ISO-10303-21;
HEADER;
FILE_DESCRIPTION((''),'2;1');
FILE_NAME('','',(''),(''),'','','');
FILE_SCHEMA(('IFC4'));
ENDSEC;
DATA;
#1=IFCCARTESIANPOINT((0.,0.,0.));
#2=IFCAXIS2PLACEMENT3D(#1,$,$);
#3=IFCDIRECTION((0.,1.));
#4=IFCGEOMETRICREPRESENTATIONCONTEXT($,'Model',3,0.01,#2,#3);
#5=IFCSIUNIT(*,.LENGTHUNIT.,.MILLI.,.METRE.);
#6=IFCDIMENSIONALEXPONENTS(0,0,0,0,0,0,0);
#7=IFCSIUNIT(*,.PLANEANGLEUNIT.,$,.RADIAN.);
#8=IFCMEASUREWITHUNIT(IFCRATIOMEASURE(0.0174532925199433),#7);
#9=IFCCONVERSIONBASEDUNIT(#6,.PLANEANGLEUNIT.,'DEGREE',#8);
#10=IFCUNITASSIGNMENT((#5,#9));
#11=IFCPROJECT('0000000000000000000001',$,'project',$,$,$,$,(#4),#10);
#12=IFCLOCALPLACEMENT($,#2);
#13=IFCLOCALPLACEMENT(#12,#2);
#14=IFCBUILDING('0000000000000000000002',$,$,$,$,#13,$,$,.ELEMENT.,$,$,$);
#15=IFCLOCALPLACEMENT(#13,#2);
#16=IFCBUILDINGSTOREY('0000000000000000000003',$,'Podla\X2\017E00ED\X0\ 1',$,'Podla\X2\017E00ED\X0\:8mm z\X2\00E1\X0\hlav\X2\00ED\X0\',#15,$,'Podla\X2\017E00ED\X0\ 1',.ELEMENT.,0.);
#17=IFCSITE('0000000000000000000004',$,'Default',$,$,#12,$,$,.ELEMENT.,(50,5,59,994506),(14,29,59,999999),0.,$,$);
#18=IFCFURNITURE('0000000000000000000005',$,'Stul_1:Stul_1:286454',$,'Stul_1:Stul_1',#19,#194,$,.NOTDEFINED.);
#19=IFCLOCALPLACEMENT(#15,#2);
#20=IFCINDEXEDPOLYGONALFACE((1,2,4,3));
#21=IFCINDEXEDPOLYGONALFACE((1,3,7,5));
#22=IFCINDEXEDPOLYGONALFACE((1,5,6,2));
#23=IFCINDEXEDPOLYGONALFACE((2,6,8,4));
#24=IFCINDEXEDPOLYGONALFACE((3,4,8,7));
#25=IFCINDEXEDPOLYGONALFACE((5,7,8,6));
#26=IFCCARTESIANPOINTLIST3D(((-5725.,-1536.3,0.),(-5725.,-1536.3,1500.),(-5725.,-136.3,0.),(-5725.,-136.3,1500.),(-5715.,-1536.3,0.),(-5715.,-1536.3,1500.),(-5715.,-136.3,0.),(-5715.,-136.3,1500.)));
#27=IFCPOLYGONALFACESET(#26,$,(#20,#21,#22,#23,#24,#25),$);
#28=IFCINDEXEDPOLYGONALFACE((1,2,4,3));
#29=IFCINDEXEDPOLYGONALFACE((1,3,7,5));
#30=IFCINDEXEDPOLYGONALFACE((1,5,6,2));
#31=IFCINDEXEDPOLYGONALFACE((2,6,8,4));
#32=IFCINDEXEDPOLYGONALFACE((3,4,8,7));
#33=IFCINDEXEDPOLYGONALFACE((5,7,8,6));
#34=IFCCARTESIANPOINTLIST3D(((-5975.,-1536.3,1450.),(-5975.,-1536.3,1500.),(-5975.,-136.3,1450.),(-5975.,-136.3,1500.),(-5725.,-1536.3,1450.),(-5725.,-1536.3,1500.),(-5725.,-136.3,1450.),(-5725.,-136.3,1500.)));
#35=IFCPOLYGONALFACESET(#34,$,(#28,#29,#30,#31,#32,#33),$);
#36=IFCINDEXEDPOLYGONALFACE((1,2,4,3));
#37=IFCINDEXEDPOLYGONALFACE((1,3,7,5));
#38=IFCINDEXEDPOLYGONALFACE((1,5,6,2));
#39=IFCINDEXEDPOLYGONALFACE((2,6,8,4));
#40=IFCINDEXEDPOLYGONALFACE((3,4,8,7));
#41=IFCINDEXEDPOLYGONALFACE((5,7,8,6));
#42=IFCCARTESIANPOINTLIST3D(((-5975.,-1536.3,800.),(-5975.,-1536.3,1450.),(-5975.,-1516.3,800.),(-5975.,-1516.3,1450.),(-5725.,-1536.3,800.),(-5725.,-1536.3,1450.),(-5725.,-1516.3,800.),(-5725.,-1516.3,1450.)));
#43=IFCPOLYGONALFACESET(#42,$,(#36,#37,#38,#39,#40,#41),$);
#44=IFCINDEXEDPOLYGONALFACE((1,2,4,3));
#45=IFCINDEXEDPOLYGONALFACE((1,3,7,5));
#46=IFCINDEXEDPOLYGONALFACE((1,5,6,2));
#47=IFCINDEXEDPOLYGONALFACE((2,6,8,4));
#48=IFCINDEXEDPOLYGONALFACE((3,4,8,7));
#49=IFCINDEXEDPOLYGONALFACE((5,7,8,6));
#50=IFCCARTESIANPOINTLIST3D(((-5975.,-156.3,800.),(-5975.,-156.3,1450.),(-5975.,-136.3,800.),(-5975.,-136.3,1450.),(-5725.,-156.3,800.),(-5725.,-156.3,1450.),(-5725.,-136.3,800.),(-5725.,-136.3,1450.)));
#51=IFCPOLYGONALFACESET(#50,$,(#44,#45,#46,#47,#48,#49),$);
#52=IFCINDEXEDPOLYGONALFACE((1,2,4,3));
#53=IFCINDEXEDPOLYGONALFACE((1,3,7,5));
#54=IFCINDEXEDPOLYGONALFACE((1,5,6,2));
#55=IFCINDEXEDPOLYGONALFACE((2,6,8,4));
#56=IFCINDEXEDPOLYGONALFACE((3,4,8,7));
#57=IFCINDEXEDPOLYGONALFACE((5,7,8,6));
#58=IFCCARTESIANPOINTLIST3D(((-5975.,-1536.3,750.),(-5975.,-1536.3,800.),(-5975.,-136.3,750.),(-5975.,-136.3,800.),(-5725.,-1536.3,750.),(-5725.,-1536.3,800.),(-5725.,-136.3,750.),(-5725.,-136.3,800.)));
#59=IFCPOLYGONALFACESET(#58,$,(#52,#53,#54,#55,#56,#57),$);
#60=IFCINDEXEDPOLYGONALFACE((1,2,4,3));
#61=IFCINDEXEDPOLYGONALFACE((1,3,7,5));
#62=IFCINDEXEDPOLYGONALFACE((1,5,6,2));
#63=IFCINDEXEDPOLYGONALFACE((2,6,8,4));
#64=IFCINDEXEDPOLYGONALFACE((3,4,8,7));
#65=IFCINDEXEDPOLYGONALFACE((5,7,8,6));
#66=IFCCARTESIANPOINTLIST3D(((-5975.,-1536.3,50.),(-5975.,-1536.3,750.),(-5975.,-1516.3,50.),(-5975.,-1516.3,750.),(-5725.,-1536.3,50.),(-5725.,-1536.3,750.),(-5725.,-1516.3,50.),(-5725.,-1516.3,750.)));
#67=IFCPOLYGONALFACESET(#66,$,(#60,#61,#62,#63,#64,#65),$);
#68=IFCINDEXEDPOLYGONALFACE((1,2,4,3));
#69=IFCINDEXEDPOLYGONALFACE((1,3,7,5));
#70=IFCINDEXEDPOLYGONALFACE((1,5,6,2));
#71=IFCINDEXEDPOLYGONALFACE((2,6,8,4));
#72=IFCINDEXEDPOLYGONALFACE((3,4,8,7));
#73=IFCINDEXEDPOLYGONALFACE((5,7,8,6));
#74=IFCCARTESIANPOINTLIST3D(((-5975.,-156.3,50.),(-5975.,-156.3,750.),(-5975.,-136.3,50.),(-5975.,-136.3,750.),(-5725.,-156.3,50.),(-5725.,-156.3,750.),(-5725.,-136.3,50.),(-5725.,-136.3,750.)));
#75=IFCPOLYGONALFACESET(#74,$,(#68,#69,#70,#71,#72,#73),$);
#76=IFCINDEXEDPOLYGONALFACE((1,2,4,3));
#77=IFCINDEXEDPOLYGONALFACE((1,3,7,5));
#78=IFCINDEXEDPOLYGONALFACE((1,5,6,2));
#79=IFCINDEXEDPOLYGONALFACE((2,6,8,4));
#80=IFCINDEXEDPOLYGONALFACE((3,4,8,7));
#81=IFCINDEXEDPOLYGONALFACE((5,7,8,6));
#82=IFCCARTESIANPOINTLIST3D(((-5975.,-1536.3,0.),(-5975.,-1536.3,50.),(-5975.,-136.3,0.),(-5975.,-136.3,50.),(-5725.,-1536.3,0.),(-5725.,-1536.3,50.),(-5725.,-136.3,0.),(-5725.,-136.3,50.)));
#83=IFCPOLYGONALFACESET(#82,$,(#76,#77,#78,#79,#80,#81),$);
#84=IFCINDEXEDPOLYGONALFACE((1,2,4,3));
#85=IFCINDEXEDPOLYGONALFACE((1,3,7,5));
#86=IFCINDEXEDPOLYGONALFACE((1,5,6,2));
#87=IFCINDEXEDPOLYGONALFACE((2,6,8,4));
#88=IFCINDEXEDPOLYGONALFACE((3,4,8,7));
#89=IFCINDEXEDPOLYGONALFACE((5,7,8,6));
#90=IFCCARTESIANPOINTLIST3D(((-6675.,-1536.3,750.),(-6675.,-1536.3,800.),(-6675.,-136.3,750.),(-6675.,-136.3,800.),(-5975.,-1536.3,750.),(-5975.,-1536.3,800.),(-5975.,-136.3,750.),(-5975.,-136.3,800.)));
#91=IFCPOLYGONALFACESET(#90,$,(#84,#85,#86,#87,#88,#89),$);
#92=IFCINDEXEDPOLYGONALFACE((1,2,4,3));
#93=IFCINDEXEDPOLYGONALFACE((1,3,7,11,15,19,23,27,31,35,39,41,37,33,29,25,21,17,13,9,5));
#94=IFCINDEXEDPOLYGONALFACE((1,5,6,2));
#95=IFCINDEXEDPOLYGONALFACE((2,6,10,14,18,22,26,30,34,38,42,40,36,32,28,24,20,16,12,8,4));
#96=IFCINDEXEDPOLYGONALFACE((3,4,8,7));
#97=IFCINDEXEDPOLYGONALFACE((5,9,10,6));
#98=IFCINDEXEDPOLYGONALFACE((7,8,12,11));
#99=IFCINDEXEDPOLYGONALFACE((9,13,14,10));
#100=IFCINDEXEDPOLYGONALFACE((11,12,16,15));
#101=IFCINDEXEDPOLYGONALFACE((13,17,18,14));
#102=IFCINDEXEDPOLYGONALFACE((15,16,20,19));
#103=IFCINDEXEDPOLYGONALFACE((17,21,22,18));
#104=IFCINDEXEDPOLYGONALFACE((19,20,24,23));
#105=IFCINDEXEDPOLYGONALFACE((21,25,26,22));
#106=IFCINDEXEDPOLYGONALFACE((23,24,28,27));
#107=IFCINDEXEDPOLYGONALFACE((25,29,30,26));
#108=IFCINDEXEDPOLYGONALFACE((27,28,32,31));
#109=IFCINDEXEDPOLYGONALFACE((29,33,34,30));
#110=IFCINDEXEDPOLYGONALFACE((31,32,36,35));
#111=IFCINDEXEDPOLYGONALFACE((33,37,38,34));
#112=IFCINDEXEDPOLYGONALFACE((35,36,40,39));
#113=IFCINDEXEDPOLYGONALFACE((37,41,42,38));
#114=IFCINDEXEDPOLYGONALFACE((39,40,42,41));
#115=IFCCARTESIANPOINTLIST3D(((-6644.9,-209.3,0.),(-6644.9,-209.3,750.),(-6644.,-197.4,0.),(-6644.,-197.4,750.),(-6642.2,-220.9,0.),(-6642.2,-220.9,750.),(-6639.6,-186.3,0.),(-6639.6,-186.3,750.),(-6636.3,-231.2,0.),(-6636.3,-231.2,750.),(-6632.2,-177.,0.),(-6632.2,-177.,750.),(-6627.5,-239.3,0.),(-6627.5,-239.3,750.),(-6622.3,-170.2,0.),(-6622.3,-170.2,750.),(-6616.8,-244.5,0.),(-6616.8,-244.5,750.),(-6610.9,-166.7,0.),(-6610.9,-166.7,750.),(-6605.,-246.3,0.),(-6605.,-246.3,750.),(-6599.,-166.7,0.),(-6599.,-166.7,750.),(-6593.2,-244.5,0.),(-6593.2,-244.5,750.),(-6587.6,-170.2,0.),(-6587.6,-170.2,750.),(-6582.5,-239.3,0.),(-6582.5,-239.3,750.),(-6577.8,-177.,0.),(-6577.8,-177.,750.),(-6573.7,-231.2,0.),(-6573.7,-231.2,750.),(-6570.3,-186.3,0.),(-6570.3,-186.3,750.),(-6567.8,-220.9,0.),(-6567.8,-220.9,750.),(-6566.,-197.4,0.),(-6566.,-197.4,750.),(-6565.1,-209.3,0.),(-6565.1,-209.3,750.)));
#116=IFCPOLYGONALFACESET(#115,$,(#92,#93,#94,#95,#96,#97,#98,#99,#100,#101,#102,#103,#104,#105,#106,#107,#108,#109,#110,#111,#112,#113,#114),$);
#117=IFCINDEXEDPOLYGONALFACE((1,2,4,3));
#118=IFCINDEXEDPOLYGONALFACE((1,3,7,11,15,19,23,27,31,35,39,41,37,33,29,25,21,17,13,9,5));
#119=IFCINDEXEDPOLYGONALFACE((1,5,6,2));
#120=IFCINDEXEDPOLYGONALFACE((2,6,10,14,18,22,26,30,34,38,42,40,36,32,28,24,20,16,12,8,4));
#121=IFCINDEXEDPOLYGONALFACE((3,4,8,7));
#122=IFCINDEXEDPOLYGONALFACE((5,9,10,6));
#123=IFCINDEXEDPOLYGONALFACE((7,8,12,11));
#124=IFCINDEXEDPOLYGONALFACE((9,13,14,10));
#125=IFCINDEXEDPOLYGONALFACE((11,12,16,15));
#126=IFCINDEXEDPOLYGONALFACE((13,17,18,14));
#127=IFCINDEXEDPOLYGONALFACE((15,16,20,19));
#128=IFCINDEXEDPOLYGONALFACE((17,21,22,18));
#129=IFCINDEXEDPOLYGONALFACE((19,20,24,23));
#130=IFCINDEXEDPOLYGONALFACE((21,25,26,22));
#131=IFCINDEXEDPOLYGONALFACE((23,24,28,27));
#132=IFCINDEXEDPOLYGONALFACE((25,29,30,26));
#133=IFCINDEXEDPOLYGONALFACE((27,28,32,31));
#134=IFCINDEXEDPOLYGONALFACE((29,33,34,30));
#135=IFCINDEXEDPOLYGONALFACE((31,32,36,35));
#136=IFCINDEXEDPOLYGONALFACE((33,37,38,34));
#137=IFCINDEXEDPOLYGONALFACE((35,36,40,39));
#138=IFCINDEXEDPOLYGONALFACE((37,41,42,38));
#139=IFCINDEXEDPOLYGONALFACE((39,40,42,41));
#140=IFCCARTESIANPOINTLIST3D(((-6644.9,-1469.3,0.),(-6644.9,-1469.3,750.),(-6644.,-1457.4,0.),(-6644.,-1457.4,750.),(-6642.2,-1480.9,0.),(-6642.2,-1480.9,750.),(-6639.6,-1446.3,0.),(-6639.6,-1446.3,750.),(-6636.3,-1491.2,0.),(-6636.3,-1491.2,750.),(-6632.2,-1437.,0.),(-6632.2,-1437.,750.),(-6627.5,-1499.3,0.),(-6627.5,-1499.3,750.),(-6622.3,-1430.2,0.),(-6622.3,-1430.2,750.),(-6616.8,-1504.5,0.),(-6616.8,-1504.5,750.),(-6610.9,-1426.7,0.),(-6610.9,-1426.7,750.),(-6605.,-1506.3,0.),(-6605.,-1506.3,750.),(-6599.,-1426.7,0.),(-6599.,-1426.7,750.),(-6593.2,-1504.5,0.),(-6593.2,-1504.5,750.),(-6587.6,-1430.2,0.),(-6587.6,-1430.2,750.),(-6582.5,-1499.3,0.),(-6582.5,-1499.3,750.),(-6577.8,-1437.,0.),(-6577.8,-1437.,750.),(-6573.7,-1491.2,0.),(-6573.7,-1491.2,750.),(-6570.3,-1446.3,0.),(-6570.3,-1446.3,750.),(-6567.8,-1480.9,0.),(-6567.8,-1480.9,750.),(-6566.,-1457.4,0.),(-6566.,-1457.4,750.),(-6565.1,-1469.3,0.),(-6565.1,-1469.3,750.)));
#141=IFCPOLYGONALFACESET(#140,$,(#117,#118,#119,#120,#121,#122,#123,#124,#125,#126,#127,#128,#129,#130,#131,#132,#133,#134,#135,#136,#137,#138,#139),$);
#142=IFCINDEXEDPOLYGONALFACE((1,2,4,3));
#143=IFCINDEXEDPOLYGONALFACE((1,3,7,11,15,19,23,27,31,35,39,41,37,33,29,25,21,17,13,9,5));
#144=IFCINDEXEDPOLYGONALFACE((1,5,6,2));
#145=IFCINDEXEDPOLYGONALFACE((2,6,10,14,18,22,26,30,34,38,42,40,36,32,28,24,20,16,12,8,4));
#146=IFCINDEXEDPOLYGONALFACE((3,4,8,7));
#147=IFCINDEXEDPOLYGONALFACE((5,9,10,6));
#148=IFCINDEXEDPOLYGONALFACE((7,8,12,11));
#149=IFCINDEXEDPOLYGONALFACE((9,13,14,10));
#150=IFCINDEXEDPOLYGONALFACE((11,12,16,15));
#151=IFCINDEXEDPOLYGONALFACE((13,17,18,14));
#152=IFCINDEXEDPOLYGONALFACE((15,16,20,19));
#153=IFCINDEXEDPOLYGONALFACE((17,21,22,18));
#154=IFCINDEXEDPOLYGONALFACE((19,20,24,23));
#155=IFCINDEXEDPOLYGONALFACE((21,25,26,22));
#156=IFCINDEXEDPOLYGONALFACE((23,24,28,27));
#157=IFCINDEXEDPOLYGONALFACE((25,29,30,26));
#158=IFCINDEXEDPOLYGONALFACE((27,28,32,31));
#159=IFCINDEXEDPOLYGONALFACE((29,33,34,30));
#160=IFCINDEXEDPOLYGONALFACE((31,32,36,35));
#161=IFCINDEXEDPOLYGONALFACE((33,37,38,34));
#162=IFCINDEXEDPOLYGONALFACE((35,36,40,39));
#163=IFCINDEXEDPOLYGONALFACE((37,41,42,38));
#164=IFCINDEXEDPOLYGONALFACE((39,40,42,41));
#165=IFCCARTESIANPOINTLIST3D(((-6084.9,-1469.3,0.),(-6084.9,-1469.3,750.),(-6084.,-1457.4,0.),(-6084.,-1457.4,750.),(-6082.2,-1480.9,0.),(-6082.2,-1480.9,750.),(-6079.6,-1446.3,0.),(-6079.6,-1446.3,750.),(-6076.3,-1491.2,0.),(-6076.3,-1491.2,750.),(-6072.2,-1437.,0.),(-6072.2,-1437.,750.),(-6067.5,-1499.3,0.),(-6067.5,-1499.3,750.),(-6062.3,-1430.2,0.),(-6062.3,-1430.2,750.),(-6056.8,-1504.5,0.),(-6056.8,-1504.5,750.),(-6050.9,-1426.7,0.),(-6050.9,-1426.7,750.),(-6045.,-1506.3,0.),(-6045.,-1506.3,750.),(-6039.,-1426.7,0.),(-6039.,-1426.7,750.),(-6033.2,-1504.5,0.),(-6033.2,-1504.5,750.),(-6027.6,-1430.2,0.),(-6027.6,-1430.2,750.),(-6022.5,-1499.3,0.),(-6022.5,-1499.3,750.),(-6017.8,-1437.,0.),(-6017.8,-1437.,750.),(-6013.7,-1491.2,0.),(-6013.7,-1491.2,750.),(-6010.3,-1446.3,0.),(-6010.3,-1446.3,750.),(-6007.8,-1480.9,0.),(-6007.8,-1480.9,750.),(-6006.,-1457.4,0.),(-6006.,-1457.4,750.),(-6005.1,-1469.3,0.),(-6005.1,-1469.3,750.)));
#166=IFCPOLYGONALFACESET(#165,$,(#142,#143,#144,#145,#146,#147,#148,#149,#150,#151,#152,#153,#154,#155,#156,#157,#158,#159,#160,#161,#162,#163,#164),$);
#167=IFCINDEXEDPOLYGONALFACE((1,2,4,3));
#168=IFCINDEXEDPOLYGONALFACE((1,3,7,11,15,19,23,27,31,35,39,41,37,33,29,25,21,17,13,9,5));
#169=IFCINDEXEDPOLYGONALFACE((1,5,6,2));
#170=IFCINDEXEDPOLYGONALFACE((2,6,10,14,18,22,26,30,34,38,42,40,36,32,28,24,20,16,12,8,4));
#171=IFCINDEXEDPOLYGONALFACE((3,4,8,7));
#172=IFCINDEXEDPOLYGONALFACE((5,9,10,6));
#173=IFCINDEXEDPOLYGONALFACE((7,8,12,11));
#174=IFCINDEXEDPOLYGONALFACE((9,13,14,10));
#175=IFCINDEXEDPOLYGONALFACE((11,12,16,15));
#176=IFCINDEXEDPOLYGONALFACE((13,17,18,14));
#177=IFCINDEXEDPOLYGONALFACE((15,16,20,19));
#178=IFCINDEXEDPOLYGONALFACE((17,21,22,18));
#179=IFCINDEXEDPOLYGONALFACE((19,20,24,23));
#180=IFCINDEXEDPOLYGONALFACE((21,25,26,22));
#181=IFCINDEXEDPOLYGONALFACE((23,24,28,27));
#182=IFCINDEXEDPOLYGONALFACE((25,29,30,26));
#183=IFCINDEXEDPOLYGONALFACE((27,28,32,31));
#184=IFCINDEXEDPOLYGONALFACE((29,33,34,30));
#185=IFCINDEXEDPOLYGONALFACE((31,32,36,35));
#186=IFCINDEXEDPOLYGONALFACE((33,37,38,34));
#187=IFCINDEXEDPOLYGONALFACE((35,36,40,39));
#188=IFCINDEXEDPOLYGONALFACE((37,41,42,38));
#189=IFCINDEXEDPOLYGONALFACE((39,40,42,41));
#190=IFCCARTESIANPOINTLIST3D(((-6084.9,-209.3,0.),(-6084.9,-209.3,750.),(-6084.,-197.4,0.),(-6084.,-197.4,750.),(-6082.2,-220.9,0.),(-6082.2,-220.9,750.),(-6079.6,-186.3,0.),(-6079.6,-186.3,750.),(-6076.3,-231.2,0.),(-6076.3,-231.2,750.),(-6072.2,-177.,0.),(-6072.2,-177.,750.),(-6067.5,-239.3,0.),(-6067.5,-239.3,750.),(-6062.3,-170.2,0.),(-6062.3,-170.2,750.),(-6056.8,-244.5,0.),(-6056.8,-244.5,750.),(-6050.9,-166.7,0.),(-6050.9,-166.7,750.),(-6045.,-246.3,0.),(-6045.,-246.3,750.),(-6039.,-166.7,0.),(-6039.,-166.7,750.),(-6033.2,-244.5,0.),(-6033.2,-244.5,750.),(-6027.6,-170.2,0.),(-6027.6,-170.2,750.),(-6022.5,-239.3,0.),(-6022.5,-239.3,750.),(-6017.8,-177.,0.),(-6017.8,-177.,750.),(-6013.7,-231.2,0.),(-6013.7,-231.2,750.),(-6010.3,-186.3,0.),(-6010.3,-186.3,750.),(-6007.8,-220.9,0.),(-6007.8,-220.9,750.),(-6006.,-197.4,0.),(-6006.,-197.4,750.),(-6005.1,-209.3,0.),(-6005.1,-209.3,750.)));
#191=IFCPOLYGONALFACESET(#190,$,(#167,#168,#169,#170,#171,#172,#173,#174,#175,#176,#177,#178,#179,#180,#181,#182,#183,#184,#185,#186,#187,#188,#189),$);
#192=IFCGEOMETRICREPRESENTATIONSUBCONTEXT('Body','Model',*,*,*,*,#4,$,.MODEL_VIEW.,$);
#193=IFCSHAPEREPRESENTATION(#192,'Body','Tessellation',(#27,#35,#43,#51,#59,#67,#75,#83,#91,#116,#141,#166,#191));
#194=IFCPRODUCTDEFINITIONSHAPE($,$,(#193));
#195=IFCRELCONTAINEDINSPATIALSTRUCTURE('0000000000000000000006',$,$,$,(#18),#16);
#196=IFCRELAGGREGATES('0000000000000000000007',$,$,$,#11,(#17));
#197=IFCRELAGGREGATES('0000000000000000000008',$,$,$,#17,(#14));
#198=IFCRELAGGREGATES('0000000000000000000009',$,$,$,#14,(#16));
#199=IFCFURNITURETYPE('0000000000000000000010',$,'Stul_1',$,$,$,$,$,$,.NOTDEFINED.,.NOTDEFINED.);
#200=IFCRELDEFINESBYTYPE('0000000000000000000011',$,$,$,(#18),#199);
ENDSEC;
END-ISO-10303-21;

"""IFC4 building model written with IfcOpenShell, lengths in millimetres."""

from ifc_helpers import new_model, entity, si_unit, converted_unit, direction, frame, frame_2d, origin, origin_2d_with_axis, place, context, subcontext, project, spatial, rectangle, circle, extrude, source, transform, mapped, type_object, type_shapes, element, save


model = new_model("IFC4")

# Units and contexts
model_context = context("Model", 3, precision=0.01, world=origin(), true_north=direction((0.0, 1.0)))
body_context = subcontext(model_context, "Body", "Model", "MODEL_VIEW")
ifc_project = project(units=[si_unit("LENGTHUNIT", "METRE", prefix="MILLI"), converted_unit("PLANEANGLEUNIT", "DEGREE", entity("IfcRatioMeasure", 0.0174532925199433), si_unit("PLANEANGLEUNIT", "RADIAN"), dimensions=[0, 0, 0, 0, 0, 0, 0])], contexts=[model_context])

# Site, building, storey
site_placement = place(None, origin())
site = spatial("IfcSite", under=ifc_project, at=site_placement, Name="Default", CompositionType="ELEMENT", RefLatitude=(50, 5, 59, 994506), RefLongitude=(14, 29, 59, 999999), RefElevation=0.0)
building_placement = place(site_placement, origin())
building = spatial("IfcBuilding", under=site, at=building_placement, CompositionType="ELEMENT")
storey_placement = place(building_placement, origin())
storey = spatial("IfcBuildingStorey", under=building, at=storey_placement, Name="Podlaží 1", ObjectType="Podlaží:8mm záhlaví", LongName="Podlaží 1", CompositionType="ELEMENT", Elevation=0.0)

# Furniture
furniture_type = type_object("IfcFurnitureType", Name="Stul_1", AssemblyPlace="NOTDEFINED", PredefinedType="NOTDEFINED")
shared_shape_1 = source(origin(), body_context, "Body", "SweptSolid", [
    extrude(rectangle(XDim=1400.0, YDim=10.0, at=origin_2d_with_axis()), frame((0.0, 605.0, 0.0), z_axis=(0.0, 0.0, 1.0), x_axis=(-1.0, 0.0, 0.0)), (0.0, 0.0, 1.0), 1500.0),
    extrude(rectangle(XDim=1400.0, YDim=250.0, at=frame_2d((0.0, 0.0), x_axis=(1.0, 0.0))), frame((0.0, 475.0, 1450.0), z_axis=(0.0, 0.0, 1.0), x_axis=(-1.0, 0.0, 0.0)), (0.0, 0.0, 1.0), 50.0),
    extrude(rectangle(XDim=20.0, YDim=250.0, at=origin_2d_with_axis()), frame((690.0, 475.0, 800.0), z_axis=(0.0, 0.0, 1.0), x_axis=(-1.0, 0.0, 0.0)), (0.0, 0.0, 1.0), 650.0),
    extrude(rectangle(XDim=20.0, YDim=250.0, at=frame_2d((0.0, 0.0), x_axis=(1.0, 0.0))), frame((-690.0, 475.0, 800.0), z_axis=(0.0, 0.0, 1.0), x_axis=(-1.0, 0.0, 0.0)), (0.0, 0.0, 1.0), 650.0),
    extrude(rectangle(XDim=1400.0, YDim=250.0, at=origin_2d_with_axis()), frame((0.0, 475.0, 750.0), z_axis=(0.0, 0.0, 1.0), x_axis=(-1.0, 0.0, 0.0)), (0.0, 0.0, 1.0), 50.0),
    extrude(rectangle(XDim=20.0, YDim=250.0, at=origin_2d_with_axis()), frame((690.0, 475.0, 50.0), z_axis=(0.0, 0.0, 1.0), x_axis=(-1.0, 0.0, 0.0)), (0.0, 0.0, 1.0), 700.0),
    extrude(rectangle(XDim=20.0, YDim=250.0, at=frame_2d((0.0, 0.0), x_axis=(1.0, 0.0))), frame((-690.0, 475.0, 50.0), z_axis=(0.0, 0.0, 1.0), x_axis=(-1.0, 0.0, 0.0)), (0.0, 0.0, 1.0), 700.0),
    extrude(rectangle(XDim=1400.0, YDim=250.0, at=origin_2d_with_axis()), frame((0.0, 475.0, 0.0), z_axis=(0.0, 0.0, 1.0), x_axis=(-1.0, 0.0, 0.0)), (0.0, 0.0, 1.0), 50.0),
    extrude(rectangle(XDim=1400.0, YDim=700.0, at=origin_2d_with_axis()), frame((0.0, 0.0, 750.0), z_axis=(0.0, 0.0, 1.0), x_axis=(-1.0, 0.0, 0.0)), (0.0, 0.0, 1.0), 50.0),
    extrude(circle(Radius=40.0, at=frame_2d((0.0, 0.0), x_axis=(1.0, 0.0))), frame((-630.0, -280.0, 0.0)), (0.0, 0.0, 1.0), 750.0),
    extrude(circle(Radius=40.0, at=frame_2d((0.0, 0.0), x_axis=(1.0, 0.0))), frame((630.0, -280.0, 0.0)), (0.0, 0.0, 1.0), 750.0),
    extrude(circle(Radius=40.0, at=frame_2d((0.0, 0.0), x_axis=(1.0, 0.0))), frame((630.0, 280.0, 0.0)), (0.0, 0.0, 1.0), 750.0),
    extrude(circle(Radius=40.0, at=frame_2d((0.0, 0.0), x_axis=(1.0, 0.0))), frame((-630.0, 280.0, 0.0)), (0.0, 0.0, 1.0), 750.0),
])
type_shapes(furniture_type, [shared_shape_1])
for number, where, z_axis, x_axis, name in (
    (1, (-6325.0, -836.3, 0.0), (0.0, 0.0, 1.0), (0.0, -1.0, 0.0), "Stul_1:Stul_1:286454"),
):
    element("IfcFurniture", number, at=place(storey_placement, frame(where, z_axis=z_axis, x_axis=x_axis)), inside=storey, type_object=furniture_type, Name=name, ObjectType="Stul_1:Stul_1", PredefinedType="NOTDEFINED", context=body_context, shape_type="MappedRepresentation", body=[
        mapped(shared_shape_1, transform((0.0, 0.0, 0.0), scale=1.0)),
    ])

save(model, "model.ifc")
